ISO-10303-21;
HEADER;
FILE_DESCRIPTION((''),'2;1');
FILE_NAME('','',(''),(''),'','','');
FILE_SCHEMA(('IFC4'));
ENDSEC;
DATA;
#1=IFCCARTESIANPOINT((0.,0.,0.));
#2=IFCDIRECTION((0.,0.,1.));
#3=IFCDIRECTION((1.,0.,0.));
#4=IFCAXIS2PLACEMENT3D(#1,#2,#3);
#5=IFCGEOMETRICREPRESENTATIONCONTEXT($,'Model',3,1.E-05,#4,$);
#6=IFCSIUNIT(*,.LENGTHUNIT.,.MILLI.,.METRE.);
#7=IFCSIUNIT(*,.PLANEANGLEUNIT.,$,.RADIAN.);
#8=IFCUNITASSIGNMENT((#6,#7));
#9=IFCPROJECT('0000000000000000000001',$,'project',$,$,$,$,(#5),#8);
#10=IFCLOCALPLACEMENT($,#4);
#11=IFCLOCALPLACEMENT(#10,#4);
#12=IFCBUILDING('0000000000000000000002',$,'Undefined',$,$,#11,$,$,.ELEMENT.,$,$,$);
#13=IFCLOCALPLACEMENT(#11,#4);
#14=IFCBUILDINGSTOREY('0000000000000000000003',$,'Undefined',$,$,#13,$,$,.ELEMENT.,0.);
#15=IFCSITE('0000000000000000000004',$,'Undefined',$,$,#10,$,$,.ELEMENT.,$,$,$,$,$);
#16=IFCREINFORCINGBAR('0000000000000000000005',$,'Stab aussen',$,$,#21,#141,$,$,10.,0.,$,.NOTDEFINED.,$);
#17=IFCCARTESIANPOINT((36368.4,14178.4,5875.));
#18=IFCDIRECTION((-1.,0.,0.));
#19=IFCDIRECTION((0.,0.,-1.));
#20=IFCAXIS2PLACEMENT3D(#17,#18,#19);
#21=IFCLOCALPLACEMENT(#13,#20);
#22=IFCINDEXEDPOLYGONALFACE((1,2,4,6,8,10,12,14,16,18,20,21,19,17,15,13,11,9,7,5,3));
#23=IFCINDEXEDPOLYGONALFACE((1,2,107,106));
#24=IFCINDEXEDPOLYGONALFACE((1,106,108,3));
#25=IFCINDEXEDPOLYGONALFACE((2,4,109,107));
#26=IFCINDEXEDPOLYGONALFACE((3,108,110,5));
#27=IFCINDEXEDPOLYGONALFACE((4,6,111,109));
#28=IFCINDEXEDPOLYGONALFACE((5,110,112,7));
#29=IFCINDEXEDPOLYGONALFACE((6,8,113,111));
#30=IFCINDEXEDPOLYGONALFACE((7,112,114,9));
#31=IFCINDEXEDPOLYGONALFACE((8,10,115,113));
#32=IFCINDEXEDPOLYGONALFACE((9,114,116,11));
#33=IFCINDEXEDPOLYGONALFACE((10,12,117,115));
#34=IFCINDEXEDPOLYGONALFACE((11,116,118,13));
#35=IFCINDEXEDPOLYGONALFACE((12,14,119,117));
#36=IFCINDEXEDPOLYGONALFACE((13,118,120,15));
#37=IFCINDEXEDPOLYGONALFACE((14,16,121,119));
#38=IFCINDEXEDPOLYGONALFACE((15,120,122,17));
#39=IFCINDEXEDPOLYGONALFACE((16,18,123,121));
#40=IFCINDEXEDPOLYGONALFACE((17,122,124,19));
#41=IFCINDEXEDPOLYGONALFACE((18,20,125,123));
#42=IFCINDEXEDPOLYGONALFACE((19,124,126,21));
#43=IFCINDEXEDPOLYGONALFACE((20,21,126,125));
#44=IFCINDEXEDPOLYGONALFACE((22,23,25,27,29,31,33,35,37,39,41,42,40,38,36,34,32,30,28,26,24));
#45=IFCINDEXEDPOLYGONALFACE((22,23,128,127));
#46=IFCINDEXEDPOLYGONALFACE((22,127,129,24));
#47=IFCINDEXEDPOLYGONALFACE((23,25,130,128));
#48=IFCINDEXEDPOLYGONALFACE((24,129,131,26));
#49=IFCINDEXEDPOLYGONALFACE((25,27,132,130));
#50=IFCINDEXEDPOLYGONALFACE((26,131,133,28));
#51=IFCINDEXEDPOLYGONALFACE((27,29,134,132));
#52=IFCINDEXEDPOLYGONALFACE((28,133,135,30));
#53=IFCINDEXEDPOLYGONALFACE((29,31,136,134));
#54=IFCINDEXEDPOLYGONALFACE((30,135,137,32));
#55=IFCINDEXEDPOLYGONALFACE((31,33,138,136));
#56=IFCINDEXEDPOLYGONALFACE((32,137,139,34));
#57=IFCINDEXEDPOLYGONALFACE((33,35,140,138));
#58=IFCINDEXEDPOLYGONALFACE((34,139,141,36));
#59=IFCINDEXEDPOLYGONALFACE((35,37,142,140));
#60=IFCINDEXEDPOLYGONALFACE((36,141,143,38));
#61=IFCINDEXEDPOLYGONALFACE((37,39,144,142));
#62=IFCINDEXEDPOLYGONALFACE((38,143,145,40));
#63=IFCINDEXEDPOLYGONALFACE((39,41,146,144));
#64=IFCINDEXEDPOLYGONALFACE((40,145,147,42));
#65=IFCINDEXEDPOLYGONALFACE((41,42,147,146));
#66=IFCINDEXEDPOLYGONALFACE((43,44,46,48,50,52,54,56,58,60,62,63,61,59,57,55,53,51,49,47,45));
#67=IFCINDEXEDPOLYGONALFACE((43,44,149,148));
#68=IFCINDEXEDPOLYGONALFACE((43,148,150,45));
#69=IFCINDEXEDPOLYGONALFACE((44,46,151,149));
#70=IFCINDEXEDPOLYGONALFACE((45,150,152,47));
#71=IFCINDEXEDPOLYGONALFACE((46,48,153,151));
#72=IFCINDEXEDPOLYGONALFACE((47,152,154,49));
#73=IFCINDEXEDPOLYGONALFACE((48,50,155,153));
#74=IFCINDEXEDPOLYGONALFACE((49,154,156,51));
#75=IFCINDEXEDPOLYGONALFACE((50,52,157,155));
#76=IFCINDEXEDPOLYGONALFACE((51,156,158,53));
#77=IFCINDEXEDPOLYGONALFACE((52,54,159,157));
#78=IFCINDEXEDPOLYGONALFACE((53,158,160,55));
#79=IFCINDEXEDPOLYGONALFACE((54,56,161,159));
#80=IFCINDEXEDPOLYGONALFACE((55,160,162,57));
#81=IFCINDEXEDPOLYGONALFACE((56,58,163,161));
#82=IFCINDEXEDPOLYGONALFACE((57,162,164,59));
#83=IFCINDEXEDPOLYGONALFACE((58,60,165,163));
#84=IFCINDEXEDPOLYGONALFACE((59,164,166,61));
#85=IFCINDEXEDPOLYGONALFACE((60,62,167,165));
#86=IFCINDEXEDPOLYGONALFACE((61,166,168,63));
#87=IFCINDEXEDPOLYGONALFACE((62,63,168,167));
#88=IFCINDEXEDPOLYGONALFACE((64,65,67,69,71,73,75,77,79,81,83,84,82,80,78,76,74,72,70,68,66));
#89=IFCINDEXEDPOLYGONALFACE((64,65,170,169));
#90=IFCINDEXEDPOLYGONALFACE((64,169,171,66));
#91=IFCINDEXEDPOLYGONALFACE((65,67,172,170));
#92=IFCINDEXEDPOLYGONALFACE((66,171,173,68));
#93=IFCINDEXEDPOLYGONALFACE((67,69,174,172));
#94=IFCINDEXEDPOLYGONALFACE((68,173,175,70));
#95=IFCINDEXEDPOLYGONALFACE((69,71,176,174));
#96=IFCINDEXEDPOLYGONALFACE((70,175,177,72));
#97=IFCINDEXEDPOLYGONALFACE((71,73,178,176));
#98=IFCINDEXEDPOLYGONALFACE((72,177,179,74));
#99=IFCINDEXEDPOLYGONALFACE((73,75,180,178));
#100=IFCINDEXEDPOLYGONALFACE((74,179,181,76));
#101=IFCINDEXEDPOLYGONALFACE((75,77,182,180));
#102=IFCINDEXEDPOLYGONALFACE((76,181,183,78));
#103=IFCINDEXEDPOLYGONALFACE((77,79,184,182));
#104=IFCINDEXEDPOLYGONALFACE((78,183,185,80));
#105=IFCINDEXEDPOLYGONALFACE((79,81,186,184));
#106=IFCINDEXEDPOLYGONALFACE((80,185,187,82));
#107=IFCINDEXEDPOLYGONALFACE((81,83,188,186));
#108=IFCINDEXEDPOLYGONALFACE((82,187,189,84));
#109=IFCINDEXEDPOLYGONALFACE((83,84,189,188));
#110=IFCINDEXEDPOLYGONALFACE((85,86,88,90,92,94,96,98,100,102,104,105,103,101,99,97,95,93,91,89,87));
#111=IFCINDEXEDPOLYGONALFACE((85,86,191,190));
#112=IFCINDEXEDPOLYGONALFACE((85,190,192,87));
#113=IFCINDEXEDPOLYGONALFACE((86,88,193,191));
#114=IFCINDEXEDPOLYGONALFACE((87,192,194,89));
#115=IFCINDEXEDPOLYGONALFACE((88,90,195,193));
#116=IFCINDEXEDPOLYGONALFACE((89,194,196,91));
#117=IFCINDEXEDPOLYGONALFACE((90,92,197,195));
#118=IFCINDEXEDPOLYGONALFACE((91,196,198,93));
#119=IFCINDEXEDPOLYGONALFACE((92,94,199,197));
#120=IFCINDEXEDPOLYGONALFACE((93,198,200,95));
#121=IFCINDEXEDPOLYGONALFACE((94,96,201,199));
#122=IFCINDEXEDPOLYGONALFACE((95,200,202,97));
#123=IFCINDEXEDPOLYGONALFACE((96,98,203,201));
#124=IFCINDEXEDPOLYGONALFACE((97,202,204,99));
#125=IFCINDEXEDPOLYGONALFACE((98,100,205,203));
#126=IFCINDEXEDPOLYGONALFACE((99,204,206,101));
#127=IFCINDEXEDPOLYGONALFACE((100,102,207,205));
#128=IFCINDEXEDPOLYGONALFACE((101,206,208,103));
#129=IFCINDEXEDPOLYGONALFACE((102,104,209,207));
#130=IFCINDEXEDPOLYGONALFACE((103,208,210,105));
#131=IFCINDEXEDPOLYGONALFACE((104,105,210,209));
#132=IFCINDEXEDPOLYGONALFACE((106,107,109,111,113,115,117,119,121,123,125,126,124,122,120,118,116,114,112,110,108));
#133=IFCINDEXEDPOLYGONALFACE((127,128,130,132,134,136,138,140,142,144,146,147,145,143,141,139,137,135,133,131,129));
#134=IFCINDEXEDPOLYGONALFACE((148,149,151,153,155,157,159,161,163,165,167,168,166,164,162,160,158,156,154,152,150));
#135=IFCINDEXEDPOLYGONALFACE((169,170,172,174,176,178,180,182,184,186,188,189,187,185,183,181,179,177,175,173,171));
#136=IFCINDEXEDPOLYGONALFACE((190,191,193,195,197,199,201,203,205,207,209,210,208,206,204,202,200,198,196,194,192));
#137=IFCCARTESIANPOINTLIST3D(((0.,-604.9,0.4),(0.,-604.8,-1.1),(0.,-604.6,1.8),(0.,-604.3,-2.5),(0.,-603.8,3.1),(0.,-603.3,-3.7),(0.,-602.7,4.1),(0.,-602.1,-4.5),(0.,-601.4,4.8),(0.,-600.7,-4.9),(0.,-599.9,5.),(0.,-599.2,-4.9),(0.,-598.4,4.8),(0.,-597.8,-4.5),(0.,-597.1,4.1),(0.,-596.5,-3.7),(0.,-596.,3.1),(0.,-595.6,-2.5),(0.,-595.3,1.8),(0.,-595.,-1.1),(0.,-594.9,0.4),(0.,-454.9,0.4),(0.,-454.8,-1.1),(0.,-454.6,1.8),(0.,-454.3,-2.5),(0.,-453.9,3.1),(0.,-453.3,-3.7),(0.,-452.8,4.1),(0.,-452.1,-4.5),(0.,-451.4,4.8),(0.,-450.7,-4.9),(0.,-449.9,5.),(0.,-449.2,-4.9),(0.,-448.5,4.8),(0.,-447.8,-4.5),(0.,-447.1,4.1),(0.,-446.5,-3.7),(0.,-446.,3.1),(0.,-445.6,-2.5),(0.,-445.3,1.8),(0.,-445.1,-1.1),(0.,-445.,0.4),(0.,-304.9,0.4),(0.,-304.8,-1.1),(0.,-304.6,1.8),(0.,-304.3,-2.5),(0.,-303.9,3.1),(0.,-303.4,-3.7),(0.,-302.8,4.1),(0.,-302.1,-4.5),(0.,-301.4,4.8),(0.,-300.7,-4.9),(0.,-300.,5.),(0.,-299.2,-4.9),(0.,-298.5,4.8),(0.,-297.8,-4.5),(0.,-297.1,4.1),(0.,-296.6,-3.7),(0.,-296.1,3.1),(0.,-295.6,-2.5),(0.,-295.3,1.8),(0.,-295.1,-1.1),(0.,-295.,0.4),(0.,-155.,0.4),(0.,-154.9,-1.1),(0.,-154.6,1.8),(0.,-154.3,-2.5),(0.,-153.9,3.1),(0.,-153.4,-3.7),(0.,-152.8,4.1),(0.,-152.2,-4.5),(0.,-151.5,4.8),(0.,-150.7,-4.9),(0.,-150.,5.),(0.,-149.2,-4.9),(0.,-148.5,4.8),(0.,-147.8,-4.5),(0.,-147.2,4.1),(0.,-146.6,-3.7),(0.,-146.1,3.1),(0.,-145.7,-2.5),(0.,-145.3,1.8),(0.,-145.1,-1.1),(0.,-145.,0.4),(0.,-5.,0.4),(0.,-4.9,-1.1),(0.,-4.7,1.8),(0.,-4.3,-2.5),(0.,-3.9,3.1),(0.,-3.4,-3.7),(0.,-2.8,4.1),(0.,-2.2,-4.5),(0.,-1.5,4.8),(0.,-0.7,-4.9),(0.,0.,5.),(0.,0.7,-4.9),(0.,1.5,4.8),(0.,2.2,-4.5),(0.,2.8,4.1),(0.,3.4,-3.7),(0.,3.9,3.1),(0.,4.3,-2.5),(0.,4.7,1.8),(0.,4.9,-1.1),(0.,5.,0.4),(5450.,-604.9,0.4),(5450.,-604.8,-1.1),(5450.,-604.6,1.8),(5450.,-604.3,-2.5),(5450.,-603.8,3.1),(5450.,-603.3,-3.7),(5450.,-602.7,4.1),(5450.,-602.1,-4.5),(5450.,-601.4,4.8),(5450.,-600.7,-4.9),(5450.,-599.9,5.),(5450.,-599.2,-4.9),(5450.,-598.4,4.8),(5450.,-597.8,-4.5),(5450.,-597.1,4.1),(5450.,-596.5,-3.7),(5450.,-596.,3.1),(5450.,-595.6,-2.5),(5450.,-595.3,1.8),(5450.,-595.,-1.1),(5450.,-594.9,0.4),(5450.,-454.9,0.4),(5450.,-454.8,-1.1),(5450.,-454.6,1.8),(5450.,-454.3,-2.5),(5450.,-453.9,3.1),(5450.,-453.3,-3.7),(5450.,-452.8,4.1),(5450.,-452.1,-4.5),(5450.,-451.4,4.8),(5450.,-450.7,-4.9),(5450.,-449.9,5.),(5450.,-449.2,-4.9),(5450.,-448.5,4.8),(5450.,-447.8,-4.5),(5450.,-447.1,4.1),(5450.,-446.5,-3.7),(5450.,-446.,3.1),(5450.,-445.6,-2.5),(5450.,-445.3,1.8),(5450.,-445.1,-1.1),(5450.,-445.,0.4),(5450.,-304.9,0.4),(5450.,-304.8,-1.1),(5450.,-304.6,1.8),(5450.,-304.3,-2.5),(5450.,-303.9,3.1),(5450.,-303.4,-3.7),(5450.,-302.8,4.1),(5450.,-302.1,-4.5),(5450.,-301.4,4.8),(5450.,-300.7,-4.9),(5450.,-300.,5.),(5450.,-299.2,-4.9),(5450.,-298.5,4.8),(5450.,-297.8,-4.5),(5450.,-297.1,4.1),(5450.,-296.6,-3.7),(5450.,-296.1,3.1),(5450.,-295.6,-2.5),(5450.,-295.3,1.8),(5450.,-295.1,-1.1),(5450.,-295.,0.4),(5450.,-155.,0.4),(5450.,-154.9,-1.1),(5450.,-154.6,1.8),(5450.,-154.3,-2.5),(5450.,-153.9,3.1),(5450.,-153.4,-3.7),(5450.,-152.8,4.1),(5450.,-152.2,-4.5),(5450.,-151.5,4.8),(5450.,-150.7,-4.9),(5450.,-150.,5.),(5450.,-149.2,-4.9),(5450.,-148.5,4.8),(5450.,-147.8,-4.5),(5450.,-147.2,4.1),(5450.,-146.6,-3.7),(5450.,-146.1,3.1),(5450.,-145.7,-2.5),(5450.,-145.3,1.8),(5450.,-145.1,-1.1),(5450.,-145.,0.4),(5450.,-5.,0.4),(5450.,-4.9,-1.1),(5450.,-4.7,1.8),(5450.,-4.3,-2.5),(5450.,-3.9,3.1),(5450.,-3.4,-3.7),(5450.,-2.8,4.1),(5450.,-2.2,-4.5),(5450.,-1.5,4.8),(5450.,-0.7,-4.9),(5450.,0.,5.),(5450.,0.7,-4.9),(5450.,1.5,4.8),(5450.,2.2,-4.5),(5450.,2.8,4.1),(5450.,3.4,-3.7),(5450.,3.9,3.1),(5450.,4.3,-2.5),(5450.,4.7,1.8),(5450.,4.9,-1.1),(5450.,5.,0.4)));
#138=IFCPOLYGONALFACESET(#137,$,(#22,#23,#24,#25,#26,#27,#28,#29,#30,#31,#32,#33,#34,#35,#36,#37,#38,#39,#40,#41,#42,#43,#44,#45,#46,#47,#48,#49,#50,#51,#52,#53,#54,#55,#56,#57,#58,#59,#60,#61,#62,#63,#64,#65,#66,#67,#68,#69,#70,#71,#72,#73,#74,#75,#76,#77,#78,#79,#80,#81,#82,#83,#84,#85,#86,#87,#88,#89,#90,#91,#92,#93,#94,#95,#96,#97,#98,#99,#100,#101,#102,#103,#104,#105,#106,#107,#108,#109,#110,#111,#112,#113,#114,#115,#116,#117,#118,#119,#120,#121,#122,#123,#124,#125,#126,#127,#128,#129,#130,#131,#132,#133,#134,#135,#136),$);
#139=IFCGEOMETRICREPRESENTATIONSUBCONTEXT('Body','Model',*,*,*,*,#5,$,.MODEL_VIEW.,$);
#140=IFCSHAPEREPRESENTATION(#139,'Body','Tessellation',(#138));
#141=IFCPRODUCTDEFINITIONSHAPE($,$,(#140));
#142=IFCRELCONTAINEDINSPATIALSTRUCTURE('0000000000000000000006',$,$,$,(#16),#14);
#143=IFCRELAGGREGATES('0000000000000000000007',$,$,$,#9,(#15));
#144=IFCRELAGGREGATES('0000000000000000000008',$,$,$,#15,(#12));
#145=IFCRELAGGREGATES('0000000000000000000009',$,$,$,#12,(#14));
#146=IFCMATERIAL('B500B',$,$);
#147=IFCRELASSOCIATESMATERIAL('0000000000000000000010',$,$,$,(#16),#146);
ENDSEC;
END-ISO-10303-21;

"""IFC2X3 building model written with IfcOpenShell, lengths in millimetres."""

from ifc_helpers import new_model, entity, si_unit, frame, origin_with_axes, place, context, subcontext, project, spatial, source, transform, mapped, material, element, save


model = new_model("IFC2X3")

# Units and contexts
model_context = context("Model", 3, precision=1e-05, world=origin_with_axes())
body_context = subcontext(model_context, "Body", "Model", "MODEL_VIEW")
ifc_project = project(units=[si_unit("LENGTHUNIT", "METRE", prefix="MILLI"), si_unit("PLANEANGLEUNIT", "RADIAN")], contexts=[model_context])

# Site, building, storey
site_placement = place(None, origin_with_axes())
site = spatial("IfcSite", under=ifc_project, at=site_placement, Name="Undefined", CompositionType="ELEMENT")
building_placement = place(site_placement, origin_with_axes())
building = spatial("IfcBuilding", under=site, at=building_placement, Name="Undefined", CompositionType="ELEMENT")
storey_placement = place(building_placement, origin_with_axes())
storey = spatial("IfcBuildingStorey", under=building, at=storey_placement, Name="Undefined", CompositionType="ELEMENT", Elevation=0.0)

# Reinforcing bar
ifc_material_1 = material(Name="B500B")
shared_shape_1 = source(origin_with_axes(), body_context, "Body", "AdvancedSweptSolid", [
    entity("IfcSweptDiskSolid", entity("IfcTrimmedCurve", entity("IfcLine", entity("IfcCartesianPoint", [0.0, 0.0, 0.0]), entity("IfcVector", entity("IfcDirection", [1.0, 0.0, 0.0]), 1.0)), [entity("IfcParameterValue", 0.0)], [entity("IfcParameterValue", 5450.0)], True, "PARAMETER"), 5.0, None, 0.0, 5450.0),
])
shared_shape_2 = source(origin_with_axes(), body_context, "Body", "AdvancedSweptSolid", [
    entity("IfcSweptDiskSolid", entity("IfcTrimmedCurve", entity("IfcLine", entity("IfcCartesianPoint", [0.0, 0.0, 0.0]), entity("IfcVector", entity("IfcDirection", [1.0, 0.0, 0.0]), 1.0)), [entity("IfcParameterValue", 0.0)], [entity("IfcParameterValue", 5450.0)], True, "PARAMETER"), 5.0, None, 0.0, 5450.0),
])
shared_shape_3 = source(origin_with_axes(), body_context, "Body", "AdvancedSweptSolid", [
    entity("IfcSweptDiskSolid", entity("IfcTrimmedCurve", entity("IfcLine", entity("IfcCartesianPoint", [0.0, 0.0, 0.0]), entity("IfcVector", entity("IfcDirection", [1.0, 0.0, 0.0]), 1.0)), [entity("IfcParameterValue", 0.0)], [entity("IfcParameterValue", 5450.0)], True, "PARAMETER"), 5.0, None, 0.0, 5450.0),
])
shared_shape_4 = source(origin_with_axes(), body_context, "Body", "AdvancedSweptSolid", [
    entity("IfcSweptDiskSolid", entity("IfcTrimmedCurve", entity("IfcLine", entity("IfcCartesianPoint", [0.0, 0.0, 0.0]), entity("IfcVector", entity("IfcDirection", [1.0, 0.0, 0.0]), 1.0)), [entity("IfcParameterValue", 0.0)], [entity("IfcParameterValue", 5450.0)], True, "PARAMETER"), 5.0, None, 0.0, 5450.0),
])
shared_shape_5 = source(origin_with_axes(), body_context, "Body", "AdvancedSweptSolid", [
    entity("IfcSweptDiskSolid", entity("IfcTrimmedCurve", entity("IfcLine", entity("IfcCartesianPoint", [0.0, 0.0, 0.0]), entity("IfcVector", entity("IfcDirection", [1.0, 0.0, 0.0]), 1.0)), [entity("IfcParameterValue", 0.0)], [entity("IfcParameterValue", 5450.0)], True, "PARAMETER"), 5.0, None, 0.0, 5450.0),
])
reinforcing_bar_1_placement = place(storey_placement, frame((36368.4, 14178.4, 5875.0), z_axis=(-1.0, 0.0, 0.0), x_axis=(0.0, 0.0, -1.0)))
element("IfcReinforcingBar", 1, at=reinforcing_bar_1_placement, inside=storey, material=ifc_material_1, Name="Stab aussen", BarRole="NOTDEFINED", CrossSectionArea=0.0, NominalDiameter=10.0, context=body_context, shape_type="MappedRepresentation", body=[
    mapped(shared_shape_1, transform((0.0, 0.0, 0.0))),
    mapped(shared_shape_2, transform((0.0, -150.0, 0.0))),
    mapped(shared_shape_3, transform((0.0, -300.0, 0.0))),
    mapped(shared_shape_4, transform((0.0, -449.9, 0.0))),
    mapped(shared_shape_5, transform((0.0, -599.9, 0.0))),
])

save(model, "model.ifc")
